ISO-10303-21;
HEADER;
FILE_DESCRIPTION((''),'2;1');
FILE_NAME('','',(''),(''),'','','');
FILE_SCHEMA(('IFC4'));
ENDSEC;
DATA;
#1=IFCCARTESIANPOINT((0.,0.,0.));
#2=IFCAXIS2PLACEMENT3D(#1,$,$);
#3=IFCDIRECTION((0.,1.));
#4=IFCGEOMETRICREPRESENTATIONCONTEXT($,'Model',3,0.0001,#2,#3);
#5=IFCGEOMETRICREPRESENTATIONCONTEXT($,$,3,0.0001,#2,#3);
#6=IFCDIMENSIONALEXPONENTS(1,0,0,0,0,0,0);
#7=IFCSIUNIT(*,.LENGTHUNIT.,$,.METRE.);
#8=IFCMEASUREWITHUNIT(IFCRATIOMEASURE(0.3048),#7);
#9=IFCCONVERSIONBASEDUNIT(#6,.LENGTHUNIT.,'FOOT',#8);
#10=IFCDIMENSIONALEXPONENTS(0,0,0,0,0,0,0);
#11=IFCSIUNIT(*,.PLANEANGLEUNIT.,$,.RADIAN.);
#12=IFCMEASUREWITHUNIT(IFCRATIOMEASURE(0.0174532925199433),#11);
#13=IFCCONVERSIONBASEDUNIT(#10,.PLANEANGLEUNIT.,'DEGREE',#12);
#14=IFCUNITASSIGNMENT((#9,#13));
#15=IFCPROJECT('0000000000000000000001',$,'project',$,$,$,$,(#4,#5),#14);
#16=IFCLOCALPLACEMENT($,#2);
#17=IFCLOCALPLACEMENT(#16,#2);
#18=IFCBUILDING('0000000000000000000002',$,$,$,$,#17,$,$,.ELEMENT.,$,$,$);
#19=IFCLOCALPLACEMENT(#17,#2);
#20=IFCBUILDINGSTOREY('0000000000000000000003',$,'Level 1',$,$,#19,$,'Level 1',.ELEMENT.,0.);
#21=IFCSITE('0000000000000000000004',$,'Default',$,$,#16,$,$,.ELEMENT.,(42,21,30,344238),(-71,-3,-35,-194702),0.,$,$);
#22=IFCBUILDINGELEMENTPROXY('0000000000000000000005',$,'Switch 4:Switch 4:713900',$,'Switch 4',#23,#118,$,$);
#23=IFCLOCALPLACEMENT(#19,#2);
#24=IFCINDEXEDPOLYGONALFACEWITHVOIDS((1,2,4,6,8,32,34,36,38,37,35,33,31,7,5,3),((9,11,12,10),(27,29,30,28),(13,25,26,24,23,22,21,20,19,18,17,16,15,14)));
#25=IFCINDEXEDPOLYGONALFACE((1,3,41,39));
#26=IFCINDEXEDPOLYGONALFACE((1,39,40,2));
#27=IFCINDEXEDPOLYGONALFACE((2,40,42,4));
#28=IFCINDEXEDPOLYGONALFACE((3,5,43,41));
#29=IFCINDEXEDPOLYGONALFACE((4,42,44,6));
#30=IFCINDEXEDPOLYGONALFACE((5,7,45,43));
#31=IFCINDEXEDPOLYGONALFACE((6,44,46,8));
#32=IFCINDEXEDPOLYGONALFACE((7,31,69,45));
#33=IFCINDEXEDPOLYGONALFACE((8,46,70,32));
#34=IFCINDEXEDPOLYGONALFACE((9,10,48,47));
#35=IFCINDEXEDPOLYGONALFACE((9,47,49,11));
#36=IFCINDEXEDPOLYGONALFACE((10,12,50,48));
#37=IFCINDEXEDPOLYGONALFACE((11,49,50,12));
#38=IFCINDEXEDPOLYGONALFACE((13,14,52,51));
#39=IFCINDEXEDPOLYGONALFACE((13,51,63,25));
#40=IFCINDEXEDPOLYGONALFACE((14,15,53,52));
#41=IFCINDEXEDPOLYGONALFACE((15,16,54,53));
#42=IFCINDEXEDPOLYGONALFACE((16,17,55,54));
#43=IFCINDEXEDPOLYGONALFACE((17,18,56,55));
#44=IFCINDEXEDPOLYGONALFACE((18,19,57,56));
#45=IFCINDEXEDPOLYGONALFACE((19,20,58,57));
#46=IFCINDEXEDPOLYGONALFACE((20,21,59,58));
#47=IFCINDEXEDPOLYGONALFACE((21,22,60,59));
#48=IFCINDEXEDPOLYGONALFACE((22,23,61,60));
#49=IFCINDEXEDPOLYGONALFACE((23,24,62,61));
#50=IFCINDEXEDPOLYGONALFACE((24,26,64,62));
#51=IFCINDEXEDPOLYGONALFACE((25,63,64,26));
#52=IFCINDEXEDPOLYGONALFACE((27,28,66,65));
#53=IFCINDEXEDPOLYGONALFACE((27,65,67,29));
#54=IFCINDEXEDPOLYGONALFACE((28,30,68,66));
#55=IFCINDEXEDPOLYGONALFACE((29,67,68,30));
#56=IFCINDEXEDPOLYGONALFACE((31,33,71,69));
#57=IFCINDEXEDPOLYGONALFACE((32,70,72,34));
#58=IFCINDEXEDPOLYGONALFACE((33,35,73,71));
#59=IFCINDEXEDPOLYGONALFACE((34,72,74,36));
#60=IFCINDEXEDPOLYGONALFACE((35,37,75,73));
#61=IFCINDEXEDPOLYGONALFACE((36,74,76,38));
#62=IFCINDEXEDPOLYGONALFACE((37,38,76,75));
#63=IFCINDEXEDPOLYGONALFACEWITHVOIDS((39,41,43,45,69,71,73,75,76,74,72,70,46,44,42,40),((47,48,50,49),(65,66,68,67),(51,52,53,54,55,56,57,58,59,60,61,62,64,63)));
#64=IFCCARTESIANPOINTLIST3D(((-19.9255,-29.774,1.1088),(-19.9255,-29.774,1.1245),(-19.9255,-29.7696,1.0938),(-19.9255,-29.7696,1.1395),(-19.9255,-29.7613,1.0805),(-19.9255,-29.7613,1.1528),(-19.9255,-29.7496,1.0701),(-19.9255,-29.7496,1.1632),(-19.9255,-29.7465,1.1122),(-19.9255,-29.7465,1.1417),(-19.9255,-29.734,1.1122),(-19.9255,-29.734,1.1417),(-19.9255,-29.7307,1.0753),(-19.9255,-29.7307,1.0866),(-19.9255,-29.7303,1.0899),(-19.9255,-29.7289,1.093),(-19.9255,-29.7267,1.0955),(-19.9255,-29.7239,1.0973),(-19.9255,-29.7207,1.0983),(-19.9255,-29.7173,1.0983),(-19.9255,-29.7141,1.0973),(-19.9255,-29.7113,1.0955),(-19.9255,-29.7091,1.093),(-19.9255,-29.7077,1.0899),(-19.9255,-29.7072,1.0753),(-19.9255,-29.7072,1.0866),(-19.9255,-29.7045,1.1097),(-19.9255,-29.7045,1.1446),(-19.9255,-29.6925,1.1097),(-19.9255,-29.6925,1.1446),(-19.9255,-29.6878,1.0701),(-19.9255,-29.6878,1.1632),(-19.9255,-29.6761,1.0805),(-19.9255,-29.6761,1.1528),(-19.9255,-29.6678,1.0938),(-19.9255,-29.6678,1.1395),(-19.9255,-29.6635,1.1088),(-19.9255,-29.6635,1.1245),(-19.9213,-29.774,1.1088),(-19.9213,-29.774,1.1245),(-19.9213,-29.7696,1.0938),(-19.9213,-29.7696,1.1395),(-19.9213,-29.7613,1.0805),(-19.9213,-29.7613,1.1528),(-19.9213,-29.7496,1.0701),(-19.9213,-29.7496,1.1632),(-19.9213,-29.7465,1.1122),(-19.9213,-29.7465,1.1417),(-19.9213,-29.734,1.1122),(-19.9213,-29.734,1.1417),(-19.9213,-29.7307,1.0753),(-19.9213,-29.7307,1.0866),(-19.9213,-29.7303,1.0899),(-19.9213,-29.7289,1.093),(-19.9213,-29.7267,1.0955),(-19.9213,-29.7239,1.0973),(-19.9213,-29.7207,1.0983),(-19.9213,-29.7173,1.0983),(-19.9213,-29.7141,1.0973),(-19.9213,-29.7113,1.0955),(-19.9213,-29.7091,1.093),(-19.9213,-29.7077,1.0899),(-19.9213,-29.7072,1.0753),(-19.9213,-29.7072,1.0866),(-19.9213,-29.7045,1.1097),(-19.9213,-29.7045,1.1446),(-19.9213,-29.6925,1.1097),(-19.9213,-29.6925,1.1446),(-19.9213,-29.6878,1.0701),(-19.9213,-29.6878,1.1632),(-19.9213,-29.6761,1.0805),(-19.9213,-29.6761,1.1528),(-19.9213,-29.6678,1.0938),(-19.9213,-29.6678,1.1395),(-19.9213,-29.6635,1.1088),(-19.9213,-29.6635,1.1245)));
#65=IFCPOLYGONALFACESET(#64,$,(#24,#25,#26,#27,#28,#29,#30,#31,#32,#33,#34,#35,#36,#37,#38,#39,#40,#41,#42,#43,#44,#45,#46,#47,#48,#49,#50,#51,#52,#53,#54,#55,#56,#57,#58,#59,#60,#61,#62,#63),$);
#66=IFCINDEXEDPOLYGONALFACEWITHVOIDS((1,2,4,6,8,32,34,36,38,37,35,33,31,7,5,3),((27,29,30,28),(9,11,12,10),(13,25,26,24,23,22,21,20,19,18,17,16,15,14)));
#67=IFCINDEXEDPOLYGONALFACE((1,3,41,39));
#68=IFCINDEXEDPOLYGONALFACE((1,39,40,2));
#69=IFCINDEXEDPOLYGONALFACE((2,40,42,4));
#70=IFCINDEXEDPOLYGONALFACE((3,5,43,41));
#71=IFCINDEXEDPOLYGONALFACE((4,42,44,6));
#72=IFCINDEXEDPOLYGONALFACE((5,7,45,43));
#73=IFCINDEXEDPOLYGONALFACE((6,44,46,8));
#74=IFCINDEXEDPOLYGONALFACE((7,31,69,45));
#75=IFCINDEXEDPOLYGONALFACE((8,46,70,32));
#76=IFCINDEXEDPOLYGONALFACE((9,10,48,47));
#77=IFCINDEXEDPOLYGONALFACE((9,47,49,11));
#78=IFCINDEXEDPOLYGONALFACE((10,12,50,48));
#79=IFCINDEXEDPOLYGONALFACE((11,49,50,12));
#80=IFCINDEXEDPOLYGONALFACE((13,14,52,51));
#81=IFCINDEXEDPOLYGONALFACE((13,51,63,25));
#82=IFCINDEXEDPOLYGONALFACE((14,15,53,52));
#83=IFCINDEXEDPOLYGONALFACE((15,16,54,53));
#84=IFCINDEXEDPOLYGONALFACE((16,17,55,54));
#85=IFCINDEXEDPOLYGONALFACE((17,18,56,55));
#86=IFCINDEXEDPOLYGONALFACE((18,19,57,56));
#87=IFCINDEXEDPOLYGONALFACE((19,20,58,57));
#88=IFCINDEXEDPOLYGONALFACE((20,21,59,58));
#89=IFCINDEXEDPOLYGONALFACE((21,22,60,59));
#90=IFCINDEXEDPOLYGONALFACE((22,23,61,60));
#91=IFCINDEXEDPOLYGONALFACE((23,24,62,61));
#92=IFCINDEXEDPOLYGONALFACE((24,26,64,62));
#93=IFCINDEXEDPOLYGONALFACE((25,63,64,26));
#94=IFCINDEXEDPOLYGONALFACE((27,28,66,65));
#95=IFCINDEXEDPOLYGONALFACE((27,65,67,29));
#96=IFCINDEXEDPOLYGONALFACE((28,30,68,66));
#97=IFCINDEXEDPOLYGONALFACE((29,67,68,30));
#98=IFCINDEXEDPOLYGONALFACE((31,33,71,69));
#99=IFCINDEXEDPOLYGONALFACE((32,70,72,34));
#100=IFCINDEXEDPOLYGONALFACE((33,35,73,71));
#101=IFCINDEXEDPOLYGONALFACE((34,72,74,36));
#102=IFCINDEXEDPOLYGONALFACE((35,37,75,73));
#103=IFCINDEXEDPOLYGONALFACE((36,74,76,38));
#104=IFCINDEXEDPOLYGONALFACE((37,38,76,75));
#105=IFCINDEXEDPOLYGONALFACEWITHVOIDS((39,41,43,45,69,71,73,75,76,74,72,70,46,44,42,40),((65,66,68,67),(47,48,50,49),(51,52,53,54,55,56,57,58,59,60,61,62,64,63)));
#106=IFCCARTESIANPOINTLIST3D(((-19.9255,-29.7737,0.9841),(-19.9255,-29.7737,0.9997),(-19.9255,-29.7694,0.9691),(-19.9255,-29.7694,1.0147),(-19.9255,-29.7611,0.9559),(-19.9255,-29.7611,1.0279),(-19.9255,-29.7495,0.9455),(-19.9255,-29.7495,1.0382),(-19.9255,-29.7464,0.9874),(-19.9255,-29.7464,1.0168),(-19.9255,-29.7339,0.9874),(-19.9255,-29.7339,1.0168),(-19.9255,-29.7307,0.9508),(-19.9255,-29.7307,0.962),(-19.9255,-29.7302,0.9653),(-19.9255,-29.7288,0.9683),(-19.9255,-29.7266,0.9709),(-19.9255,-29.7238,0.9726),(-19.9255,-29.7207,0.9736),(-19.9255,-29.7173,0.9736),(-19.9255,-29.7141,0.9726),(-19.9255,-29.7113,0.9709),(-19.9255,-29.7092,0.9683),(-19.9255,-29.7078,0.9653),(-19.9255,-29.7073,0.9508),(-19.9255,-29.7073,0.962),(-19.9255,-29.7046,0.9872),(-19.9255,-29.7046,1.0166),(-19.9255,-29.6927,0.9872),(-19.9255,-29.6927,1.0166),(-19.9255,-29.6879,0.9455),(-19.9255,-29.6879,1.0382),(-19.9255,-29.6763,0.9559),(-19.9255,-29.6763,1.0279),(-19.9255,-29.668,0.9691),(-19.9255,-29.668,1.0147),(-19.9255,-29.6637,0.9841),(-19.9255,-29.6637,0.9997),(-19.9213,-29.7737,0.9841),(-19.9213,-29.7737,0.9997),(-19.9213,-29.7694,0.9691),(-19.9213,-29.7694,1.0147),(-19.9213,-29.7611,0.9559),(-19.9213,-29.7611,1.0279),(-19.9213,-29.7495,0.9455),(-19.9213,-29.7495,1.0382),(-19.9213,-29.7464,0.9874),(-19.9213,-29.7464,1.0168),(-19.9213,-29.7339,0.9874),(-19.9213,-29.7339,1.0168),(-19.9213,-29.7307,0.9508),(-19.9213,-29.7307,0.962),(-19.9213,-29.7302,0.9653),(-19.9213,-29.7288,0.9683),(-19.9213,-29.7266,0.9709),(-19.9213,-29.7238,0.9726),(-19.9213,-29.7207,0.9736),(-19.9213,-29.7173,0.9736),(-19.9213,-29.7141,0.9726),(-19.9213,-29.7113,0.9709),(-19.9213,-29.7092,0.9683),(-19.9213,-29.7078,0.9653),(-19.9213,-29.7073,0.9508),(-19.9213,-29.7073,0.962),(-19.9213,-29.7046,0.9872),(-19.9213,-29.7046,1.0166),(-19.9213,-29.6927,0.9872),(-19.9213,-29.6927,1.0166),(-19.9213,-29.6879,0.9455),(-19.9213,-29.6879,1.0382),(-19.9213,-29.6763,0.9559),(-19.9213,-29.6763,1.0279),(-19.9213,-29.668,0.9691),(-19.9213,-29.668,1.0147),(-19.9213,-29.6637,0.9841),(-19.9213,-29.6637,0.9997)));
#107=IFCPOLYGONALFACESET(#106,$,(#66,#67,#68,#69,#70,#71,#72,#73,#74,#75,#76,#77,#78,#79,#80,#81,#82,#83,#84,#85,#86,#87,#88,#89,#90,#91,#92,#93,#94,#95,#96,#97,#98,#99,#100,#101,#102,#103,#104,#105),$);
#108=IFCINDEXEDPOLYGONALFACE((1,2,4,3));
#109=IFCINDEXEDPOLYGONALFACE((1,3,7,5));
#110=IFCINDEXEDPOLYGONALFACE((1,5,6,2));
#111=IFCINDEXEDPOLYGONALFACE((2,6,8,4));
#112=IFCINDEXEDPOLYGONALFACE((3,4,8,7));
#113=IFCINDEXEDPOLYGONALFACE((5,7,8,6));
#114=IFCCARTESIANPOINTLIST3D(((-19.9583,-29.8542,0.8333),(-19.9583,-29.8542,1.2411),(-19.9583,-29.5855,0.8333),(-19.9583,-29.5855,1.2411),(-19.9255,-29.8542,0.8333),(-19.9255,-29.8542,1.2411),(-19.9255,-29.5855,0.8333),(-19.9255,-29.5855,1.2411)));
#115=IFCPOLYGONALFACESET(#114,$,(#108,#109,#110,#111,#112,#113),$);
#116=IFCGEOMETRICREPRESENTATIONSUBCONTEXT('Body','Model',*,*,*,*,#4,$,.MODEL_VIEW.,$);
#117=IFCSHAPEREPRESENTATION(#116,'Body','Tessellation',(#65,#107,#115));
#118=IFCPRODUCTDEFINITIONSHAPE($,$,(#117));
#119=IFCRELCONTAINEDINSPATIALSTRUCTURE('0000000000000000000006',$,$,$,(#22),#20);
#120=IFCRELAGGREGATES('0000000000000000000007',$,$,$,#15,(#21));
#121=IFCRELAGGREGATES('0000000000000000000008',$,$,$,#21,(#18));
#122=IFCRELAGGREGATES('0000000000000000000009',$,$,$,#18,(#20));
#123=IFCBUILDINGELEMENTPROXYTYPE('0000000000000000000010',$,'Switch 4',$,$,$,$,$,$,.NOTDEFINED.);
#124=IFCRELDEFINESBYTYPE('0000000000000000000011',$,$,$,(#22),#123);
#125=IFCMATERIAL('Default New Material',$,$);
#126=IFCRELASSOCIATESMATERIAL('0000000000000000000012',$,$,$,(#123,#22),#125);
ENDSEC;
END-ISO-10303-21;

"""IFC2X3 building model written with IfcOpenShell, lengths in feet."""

from ifc_helpers import new_model, entity, si_unit, converted_unit, direction, frame, frame_2d, origin, origin_2d_with_axis, place, context, subcontext, project, spatial, polyline, circle_curve, parameter, trimmed, segment, composite_curve, rectangle, outline, extrude, source, transform, mapped, material, type_object, type_shapes, element, save


model = new_model("IFC2X3")

# Units and contexts
model_context = context("Model", 3, precision=0.0001, world=origin(), true_north=direction((0.0, 1.0)))
context_of_model = context(None, 3, precision=0.0001, world=origin(), true_north=direction((0.0, 1.0)))
body_context = subcontext(model_context, "Body", "Model", "MODEL_VIEW")
ifc_project = project(units=[converted_unit("LENGTHUNIT", "FOOT", entity("IfcRatioMeasure", 0.3048), si_unit("LENGTHUNIT", "METRE"), dimensions=[1, 0, 0, 0, 0, 0, 0]), converted_unit("PLANEANGLEUNIT", "DEGREE", entity("IfcRatioMeasure", 0.0174532925199433), si_unit("PLANEANGLEUNIT", "RADIAN"), dimensions=[0, 0, 0, 0, 0, 0, 0])], contexts=[model_context, context_of_model])

# Site, building, storey
site_placement = place(None, origin())
site = spatial("IfcSite", under=ifc_project, at=site_placement, Name="Default", CompositionType="ELEMENT", RefLatitude=(42, 21, 30, 344238), RefLongitude=(-71, -3, -35, -194702), RefElevation=0.0)
building_placement = place(site_placement, origin())
building = spatial("IfcBuilding", under=site, at=building_placement, CompositionType="ELEMENT")
storey_placement = place(building_placement, origin())
storey = spatial("IfcBuildingStorey", under=building, at=storey_placement, Name="Level 1", LongName="Level 1", CompositionType="ELEMENT", Elevation=0.0)

# Shared definitions
ifc_material_1 = material(Name="Default New Material")

# Building element proxy
building_element_proxy_type_1 = type_object("IfcBuildingElementProxyType", Name="Switch 4", PredefinedType="NOTDEFINED", material=ifc_material_1)
shared_shape_1 = source(origin(), body_context, "Body", "SweptSolid", [
    extrude(outline(composite_curve([segment(polyline([(-0.0309, -0.0466), (0.0309, -0.0466)]), True, "CONTINUOUS"), segment(trimmed(circle_curve(frame_2d((-0.0003, 0.0), x_axis=(-1.0, 0.0)), 0.0561), [parameter(123.794741)], [parameter(236.205259)], True, "PARAMETER"), True, "CONTINUOUS"), segment(polyline([(0.0309, 0.0466), (-0.0309, 0.0466)]), True, "CONTINUOUS"), segment(trimmed(circle_curve(frame_2d((0.0003, 0.0), x_axis=(1.0, 0.0)), 0.0561), [parameter(123.794741)], [parameter(236.205259)], True, "PARAMETER"), True, "CONTINUOUS")], self_intersect=False), holes=[polyline([(0.0142, 0.0279), (0.0262, 0.0279), (0.0262, -0.0069), (0.0142, -0.0069), (0.0142, 0.0279)]), polyline([(-0.0153, 0.025), (-0.0153, -0.0045), (-0.0278, -0.0045), (-0.0278, 0.025), (-0.0153, 0.025)]), composite_curve([segment(polyline([(-0.012, -0.0413), (-0.012, -0.03)]), True, "CONTINUOUS"), segment(trimmed(circle_curve(frame_2d((-0.0003, -0.03), x_axis=(-1.0, 0.0)), 0.0117), [parameter(180.0)], [parameter(0.0)], True, "PARAMETER"), False, "CONTINUOUS"), segment(polyline([(0.0115, -0.03), (0.0115, -0.0413)]), True, "CONTINUOUS"), segment(polyline([(0.0115, -0.0413), (-0.012, -0.0413)]), True, "CONTINUOUS")], self_intersect=False)]), frame((-0.0011, 0.0328, 0.2833), z_axis=(0.0, 1.0, 0.0), x_axis=(-1.0, 0.0, 0.0)), (0.0, 0.0, 1.0), 0.0042),
    extrude(outline(composite_curve([segment(polyline([(-0.0308, -0.0464), (0.0308, -0.0464)]), True, "CONTINUOUS"), segment(trimmed(circle_curve(frame_2d((-0.0003, 0.0), x_axis=(-1.0, 0.0)), 0.0558), [parameter(123.794741)], [parameter(236.205259)], True, "PARAMETER"), True, "CONTINUOUS"), segment(polyline([(0.0308, 0.0464), (-0.0308, 0.0464)]), True, "CONTINUOUS"), segment(trimmed(circle_curve(frame_2d((0.0003, 0.0), x_axis=(1.0, 0.0)), 0.0558), [parameter(123.794741)], [parameter(236.205259)], True, "PARAMETER"), True, "CONTINUOUS")], self_intersect=False), holes=[polyline([(0.0141, 0.0247), (0.026, 0.0247), (0.026, -0.0047), (0.0141, -0.0047), (0.0141, 0.0247)]), polyline([(-0.0152, 0.0249), (-0.0152, -0.0045), (-0.0277, -0.0045), (-0.0277, 0.0249), (-0.0152, 0.0249)]), composite_curve([segment(polyline([(-0.012, -0.0411), (-0.012, -0.0299)]), True, "CONTINUOUS"), segment(trimmed(circle_curve(frame_2d((-0.0003, -0.0299), x_axis=(-1.0, 0.0)), 0.0117), [parameter(180.0)], [parameter(0.0)], True, "PARAMETER"), False, "CONTINUOUS"), segment(polyline([(0.0114, -0.0299), (0.0114, -0.0411)]), True, "CONTINUOUS"), segment(polyline([(0.0114, -0.0411), (-0.012, -0.0411)]), True, "CONTINUOUS")], self_intersect=False)]), frame((-0.0011, 0.0328, 0.1586), z_axis=(0.0, 1.0, 0.0), x_axis=(-1.0, 0.0, 0.0)), (0.0, 0.0, 1.0), 0.0042),
    extrude(rectangle(XDim=0.0328, YDim=0.2687, at=origin_2d_with_axis()), frame((0.0, 0.0164, 0.0), z_axis=(0.0, 0.0, 1.0), x_axis=(0.0, -1.0, 0.0)), (0.0, 0.0, 1.0), 0.4078),
])
type_shapes(building_element_proxy_type_1, [shared_shape_1])
for number, where, z_axis, x_axis, name in (
    (1, (-19.9583, -29.7198, 0.8333), (0.0, 0.0, 1.0), (0.0, -1.0, 0.0), "Switch 4:Switch 4:713900"),
):
    element("IfcBuildingElementProxy", number, at=place(storey_placement, frame(where, z_axis=z_axis, x_axis=x_axis)), inside=storey, type_object=building_element_proxy_type_1, material=ifc_material_1, Name=name, ObjectType="Switch 4", context=body_context, shape_type="MappedRepresentation", body=[
        mapped(shared_shape_1, transform((0.0, 0.0, 0.0), scale=1.0)),
    ])

save(model, "model.ifc")
